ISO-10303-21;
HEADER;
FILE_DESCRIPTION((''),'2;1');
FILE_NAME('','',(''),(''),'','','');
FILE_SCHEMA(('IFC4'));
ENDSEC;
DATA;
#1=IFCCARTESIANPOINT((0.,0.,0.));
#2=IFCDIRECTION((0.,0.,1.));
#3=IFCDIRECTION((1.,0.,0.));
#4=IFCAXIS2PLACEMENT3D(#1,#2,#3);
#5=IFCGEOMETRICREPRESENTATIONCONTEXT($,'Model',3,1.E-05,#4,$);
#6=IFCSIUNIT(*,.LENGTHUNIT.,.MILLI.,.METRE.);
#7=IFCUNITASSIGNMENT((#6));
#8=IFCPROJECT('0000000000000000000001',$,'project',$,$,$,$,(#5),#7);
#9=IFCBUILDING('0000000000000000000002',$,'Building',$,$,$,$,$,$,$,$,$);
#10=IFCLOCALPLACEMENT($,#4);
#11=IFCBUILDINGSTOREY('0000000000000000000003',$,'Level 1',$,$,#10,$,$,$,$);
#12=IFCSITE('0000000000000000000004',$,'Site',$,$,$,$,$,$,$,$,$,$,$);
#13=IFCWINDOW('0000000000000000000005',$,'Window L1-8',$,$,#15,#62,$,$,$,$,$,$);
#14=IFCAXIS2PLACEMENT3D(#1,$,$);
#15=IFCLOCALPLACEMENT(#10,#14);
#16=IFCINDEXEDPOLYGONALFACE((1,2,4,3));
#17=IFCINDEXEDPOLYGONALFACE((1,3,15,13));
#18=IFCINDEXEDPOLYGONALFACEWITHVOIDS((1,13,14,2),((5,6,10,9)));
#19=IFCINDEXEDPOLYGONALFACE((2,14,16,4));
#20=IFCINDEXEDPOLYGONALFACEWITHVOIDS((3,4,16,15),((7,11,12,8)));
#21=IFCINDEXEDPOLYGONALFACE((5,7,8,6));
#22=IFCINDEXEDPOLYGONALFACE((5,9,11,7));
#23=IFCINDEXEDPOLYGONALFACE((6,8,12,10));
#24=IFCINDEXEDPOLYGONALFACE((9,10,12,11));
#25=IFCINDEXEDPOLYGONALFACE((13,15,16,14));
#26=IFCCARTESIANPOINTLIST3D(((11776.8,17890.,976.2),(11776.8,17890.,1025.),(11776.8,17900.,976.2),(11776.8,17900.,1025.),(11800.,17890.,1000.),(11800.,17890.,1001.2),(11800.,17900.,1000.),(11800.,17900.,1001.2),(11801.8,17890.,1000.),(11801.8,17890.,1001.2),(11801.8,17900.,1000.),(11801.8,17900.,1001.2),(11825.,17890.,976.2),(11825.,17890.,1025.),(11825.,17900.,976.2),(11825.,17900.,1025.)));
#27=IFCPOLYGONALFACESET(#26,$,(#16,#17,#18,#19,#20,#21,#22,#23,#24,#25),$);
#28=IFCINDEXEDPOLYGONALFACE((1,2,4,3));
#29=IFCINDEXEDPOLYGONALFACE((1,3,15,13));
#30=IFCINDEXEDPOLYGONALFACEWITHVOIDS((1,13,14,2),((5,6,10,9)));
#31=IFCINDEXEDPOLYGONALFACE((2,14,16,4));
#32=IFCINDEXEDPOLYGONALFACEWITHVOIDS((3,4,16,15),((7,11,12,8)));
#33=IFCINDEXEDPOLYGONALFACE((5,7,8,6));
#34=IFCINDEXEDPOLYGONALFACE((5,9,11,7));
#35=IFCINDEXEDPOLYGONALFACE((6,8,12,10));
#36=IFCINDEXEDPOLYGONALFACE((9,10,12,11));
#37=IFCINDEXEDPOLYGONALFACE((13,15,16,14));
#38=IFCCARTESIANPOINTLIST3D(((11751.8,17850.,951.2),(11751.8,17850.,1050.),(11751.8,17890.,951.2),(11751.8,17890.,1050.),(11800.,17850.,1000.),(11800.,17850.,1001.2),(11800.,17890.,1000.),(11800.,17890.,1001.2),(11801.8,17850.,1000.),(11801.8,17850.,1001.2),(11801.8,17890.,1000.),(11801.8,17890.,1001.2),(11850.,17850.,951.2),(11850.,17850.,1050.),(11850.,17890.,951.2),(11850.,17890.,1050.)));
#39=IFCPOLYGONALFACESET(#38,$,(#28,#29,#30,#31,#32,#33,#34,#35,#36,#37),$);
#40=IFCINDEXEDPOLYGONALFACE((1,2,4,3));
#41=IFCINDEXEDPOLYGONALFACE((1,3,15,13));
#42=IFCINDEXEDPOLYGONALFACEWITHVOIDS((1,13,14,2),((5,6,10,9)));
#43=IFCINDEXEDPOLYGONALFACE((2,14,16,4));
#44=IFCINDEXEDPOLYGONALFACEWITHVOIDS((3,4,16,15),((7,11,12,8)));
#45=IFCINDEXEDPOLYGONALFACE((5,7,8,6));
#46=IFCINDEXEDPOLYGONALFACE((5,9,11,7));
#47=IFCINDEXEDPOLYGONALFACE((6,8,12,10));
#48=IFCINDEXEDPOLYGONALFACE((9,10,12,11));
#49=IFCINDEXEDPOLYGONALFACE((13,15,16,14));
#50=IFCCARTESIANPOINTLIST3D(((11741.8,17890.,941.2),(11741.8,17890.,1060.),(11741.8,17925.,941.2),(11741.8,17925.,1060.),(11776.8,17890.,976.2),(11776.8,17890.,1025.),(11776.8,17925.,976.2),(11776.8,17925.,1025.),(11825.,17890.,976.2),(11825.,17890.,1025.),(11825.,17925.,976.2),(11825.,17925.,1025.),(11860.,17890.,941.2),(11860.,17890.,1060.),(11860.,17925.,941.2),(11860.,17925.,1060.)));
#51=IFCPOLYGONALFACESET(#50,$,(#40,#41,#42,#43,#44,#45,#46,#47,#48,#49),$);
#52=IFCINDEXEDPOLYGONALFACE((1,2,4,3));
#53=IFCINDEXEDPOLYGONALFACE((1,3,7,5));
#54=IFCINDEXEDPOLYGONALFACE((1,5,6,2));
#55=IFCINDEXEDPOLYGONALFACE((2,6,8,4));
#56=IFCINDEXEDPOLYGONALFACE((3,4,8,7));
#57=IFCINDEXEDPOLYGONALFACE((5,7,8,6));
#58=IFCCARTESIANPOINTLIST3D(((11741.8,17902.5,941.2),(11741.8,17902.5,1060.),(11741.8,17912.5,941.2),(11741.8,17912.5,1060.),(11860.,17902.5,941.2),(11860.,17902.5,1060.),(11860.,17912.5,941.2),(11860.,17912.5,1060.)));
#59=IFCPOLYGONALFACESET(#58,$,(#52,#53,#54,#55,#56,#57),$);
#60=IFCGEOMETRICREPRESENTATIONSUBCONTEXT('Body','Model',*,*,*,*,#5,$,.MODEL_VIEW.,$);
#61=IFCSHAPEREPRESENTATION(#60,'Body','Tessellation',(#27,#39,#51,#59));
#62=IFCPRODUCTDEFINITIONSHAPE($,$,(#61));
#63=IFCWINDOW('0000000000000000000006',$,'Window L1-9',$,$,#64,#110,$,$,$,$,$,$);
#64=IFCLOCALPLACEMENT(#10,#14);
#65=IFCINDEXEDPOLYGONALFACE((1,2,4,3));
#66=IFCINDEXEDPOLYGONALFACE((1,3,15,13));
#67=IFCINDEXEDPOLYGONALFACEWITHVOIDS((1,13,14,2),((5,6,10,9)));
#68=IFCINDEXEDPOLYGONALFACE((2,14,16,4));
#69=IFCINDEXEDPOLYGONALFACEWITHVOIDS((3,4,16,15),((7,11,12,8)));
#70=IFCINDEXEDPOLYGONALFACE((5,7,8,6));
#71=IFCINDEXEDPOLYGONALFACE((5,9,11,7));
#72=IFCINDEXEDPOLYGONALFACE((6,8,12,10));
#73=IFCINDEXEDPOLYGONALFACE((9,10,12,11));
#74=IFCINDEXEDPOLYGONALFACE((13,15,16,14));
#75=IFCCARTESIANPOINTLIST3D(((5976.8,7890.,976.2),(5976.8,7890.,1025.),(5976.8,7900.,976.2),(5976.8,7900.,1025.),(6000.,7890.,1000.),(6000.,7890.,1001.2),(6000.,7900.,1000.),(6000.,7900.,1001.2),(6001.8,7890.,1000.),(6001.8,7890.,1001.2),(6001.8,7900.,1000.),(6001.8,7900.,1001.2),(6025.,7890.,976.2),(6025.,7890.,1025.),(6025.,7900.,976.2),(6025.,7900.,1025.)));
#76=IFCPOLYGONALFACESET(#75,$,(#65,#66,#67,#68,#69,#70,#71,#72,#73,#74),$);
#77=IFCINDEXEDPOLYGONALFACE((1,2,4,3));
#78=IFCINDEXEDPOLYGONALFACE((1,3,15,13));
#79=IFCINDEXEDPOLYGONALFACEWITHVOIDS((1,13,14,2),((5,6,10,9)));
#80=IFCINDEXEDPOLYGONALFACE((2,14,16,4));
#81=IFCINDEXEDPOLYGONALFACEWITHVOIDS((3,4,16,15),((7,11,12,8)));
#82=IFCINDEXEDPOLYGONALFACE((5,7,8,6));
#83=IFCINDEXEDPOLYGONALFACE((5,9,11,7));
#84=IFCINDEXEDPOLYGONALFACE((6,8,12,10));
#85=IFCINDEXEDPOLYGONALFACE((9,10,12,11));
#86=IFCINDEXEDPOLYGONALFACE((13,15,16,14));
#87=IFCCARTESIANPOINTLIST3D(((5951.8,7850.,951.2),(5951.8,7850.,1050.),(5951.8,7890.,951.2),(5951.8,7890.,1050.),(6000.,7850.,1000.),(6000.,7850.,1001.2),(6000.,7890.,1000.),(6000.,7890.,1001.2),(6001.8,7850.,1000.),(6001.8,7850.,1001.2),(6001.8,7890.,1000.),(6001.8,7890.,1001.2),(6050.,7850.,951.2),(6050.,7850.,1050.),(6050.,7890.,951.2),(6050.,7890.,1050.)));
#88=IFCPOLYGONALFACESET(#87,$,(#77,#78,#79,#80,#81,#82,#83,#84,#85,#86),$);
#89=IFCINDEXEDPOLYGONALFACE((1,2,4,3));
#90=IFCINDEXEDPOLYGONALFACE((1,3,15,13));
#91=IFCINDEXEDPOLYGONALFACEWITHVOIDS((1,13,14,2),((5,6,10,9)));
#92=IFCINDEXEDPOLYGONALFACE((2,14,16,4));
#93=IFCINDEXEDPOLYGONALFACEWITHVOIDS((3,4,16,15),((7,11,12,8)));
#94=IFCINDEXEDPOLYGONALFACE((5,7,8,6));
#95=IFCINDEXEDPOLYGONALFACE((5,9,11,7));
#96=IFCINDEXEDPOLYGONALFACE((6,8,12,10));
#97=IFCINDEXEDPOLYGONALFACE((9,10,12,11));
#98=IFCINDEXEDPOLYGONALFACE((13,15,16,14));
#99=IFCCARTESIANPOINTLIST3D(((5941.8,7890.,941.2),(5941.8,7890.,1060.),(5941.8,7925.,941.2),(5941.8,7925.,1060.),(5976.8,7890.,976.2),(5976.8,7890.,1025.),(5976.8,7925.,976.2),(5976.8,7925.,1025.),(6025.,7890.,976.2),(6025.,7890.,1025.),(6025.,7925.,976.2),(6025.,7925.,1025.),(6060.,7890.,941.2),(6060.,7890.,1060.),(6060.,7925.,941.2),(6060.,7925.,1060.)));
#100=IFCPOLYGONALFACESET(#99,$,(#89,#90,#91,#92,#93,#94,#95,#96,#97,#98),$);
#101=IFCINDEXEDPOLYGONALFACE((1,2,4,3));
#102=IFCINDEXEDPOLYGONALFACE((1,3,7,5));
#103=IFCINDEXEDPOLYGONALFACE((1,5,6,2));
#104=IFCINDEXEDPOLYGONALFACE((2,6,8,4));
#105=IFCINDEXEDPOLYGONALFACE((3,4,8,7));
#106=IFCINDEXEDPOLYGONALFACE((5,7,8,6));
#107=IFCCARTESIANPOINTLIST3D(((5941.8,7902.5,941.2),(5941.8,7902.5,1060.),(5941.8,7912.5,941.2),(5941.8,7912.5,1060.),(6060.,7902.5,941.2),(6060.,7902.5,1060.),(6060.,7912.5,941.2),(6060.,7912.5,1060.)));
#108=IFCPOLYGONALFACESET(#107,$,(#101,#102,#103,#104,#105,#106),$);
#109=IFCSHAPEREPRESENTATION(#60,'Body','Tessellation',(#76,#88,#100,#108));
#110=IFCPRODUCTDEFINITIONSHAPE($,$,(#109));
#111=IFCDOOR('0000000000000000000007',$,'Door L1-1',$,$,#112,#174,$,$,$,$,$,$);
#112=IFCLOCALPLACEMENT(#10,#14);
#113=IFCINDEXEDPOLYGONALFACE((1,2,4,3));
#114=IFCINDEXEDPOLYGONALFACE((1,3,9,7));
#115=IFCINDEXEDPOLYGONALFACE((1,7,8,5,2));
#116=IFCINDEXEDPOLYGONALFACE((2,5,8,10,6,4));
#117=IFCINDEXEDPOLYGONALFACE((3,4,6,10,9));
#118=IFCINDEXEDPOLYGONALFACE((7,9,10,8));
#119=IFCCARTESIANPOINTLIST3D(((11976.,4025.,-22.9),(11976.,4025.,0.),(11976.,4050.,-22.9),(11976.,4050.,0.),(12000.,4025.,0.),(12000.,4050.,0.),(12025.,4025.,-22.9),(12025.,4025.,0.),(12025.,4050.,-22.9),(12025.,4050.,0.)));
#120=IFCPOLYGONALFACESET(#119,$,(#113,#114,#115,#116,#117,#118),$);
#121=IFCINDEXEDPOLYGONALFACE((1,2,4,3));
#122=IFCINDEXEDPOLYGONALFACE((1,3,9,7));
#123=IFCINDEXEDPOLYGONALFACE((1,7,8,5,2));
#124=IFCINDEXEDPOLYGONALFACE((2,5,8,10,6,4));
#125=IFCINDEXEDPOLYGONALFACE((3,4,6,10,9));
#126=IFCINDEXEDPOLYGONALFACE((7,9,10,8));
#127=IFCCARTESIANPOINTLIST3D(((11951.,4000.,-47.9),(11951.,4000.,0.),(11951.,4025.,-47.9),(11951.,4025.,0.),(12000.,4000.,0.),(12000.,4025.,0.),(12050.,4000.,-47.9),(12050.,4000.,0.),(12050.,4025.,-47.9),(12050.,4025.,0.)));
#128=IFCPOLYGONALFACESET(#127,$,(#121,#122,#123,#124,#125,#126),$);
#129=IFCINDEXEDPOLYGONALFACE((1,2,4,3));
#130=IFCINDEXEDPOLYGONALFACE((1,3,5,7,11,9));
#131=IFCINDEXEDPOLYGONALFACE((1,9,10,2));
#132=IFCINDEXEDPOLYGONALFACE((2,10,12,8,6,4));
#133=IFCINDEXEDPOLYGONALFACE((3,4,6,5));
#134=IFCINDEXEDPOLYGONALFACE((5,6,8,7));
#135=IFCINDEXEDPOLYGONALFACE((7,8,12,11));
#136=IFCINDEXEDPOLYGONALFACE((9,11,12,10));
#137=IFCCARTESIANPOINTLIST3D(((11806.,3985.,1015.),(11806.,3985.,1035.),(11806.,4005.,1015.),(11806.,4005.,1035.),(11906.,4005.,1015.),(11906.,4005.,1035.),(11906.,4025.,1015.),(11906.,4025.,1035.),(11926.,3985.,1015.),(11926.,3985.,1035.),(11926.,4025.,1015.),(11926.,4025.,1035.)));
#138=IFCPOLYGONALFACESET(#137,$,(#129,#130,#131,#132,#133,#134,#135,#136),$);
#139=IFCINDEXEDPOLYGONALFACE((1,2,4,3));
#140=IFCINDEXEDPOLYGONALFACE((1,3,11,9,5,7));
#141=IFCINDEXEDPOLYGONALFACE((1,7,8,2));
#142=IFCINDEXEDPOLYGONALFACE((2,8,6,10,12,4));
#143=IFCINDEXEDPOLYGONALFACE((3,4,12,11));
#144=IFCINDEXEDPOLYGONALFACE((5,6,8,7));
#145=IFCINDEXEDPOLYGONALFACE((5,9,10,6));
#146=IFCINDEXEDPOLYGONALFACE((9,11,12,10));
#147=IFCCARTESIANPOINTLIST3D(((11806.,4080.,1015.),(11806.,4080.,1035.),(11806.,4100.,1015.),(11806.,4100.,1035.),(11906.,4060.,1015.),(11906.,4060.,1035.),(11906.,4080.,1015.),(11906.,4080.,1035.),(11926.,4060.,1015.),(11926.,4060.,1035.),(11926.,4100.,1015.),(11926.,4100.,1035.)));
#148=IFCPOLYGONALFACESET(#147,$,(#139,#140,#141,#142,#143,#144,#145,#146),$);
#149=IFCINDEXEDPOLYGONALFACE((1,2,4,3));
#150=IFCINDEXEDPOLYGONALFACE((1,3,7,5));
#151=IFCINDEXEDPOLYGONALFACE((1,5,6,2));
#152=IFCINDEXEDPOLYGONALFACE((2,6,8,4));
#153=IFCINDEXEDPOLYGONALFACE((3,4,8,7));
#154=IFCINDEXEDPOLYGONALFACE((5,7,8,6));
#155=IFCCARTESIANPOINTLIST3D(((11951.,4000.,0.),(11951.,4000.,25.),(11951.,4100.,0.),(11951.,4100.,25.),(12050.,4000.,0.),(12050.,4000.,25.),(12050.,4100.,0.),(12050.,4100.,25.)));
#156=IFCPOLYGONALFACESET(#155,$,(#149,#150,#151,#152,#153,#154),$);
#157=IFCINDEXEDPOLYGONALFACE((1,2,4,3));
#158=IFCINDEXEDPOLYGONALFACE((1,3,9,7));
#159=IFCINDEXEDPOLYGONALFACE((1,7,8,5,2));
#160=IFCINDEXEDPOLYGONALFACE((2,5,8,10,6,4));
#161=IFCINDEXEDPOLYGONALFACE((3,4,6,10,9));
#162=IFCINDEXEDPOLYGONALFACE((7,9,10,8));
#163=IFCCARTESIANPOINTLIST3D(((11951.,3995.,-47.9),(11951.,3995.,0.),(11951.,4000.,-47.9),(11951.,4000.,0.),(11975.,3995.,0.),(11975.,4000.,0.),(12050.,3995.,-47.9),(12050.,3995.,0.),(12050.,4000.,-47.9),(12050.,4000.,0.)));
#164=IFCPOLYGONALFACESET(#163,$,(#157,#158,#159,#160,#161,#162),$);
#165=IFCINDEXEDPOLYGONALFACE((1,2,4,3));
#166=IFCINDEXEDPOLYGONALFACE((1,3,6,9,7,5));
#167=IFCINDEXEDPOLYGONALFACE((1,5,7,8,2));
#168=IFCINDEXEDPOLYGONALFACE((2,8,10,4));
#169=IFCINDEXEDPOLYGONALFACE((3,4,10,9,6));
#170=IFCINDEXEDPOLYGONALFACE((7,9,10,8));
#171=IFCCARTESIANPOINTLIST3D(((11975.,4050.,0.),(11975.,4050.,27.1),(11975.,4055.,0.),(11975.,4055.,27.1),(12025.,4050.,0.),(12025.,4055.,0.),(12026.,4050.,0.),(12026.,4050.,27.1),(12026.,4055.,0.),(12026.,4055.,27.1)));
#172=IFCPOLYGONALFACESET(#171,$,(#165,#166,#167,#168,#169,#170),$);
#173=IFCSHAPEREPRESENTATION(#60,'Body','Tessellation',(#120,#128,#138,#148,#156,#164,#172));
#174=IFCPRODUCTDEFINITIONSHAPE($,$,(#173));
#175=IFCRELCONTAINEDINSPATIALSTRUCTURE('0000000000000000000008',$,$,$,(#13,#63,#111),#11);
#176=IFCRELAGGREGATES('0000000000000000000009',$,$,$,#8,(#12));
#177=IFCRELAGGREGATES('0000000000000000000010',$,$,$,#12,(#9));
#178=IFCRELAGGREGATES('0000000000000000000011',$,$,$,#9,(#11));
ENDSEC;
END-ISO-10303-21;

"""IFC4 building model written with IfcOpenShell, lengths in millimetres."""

from ifc_helpers import new_model, si_unit, frame, origin_with_axes, place, context, subcontext, project, spatial, line, indexed_curve, outline, extrude, element, save


model = new_model("IFC4")

# Units and contexts
model_context = context("Model", 3, precision=1e-05, world=origin_with_axes())
body_context = subcontext(model_context, "Body", "Model", "MODEL_VIEW")
ifc_project = project(units=[si_unit("LENGTHUNIT", "METRE", prefix="MILLI")], contexts=[model_context])

# Site, building, storey
site = spatial("IfcSite", under=ifc_project, Name="Site")
building = spatial("IfcBuilding", under=site, Name="Building")
storey_placement = place(None, origin_with_axes())
storey = spatial("IfcBuildingStorey", under=building, at=storey_placement, Name="Level 1")

# Windows
for number, where, z_axis, x_axis, name in (
    (1, (11800.0, 17800.0, 1000.0), (0.0, 0.0, 1.0), (1.0, 0.0, 0.0), "Window L1-8"),
    (2, (6000.0, 7800.0, 1000.0), (0.0, 0.0, 1.0), (1.0, 0.0, 0.0), "Window L1-9"),
):
    element("IfcWindow", number, at=place(storey_placement, frame(where, z_axis=z_axis, x_axis=x_axis)), inside=storey, Name=name, context=body_context, shape_type="SweptSolid", body=[
        extrude(outline(indexed_curve([(0.0, 0.0), (1.8, 0.0), (1.8, 1.2), (0.0, 1.2)], segments=[line(1, 2, 3, 4, 1)]), holes=[indexed_curve([(25.0, 25.0), (-23.2, 25.0), (-23.2, -23.8), (25.0, -23.8)], segments=[line(1, 2, 3, 4, 1)])]), frame((0.0, 90.0, 0.0), z_axis=(0.0, -1.0, 0.0), x_axis=(1.0, 0.0, 0.0)), (0.0, 0.0, -1.0), 10.0),
        extrude(outline(indexed_curve([(0.0, 0.0), (1.8, 0.0), (1.8, 1.2), (0.0, 1.2)], segments=[line(1, 2, 3, 4, 1)]), holes=[indexed_curve([(50.0, 50.0), (-48.2, 50.0), (-48.2, -48.8), (50.0, -48.8)], segments=[line(1, 2, 3, 4, 1)])]), frame((0.0, 50.0, 0.0), z_axis=(0.0, -1.0, 0.0), x_axis=(1.0, 0.0, 0.0)), (0.0, 0.0, -1.0), 40.0),
        extrude(outline(indexed_curve([(0.0, 0.0), (-48.2, 0.0), (-48.2, -48.8), (0.0, -48.8)], segments=[line(1, 2, 3, 4, 1)]), holes=[indexed_curve([(35.0, 35.0), (-83.2, 35.0), (-83.2, -83.8), (35.0, -83.8)], segments=[line(1, 2, 3, 4, 1)])]), frame((25.0, 90.0, 25.0), z_axis=(0.0, -1.0, 0.0), x_axis=(1.0, 0.0, 0.0)), (0.0, 0.0, -1.0), 35.0),
        extrude(outline(indexed_curve([(35.0, 35.0), (-83.2, 35.0), (-83.2, -83.8), (35.0, -83.8)], segments=[line(1, 2, 3, 4, 1)])), frame((25.0, 102.5, 25.0), z_axis=(0.0, -1.0, 0.0), x_axis=(1.0, 0.0, 0.0)), (0.0, 0.0, -1.0), 10.0),
    ])

# Door
door_1_placement = place(storey_placement, frame((12000.0, 4000.0, 0.0), z_axis=(0.0, 0.0, 1.0), x_axis=(1.0, 0.0, 0.0)))
element("IfcDoor", 3, at=door_1_placement, inside=storey, Name="Door L1-1", context=body_context, shape_type="SweptSolid", body=[
    extrude(outline(indexed_curve([(0.0, 0.0), (0.0, 2.1), (1.0, 2.1), (1.0, 0.0), (-24.0, 0.0), (-24.0, -22.9), (25.0, -22.9), (25.0, 0.0)], segments=[line(1, 2, 3, 4, 5, 6, 7, 8, 1)])), frame((0.0, 25.0, 0.0), z_axis=(0.0, -1.0, 0.0), x_axis=(1.0, 0.0, 0.0)), (0.0, 0.0, -1.0), 25.0),
    extrude(outline(indexed_curve([(0.0, 0.0), (0.0, 2.1), (1.0, 2.1), (1.0, 0.0), (-49.0, 0.0), (-49.0, -47.9), (50.0, -47.9), (50.0, 0.0)], segments=[line(1, 2, 3, 4, 5, 6, 7, 8, 1)])), frame((0.0, 0.0, 0.0), z_axis=(0.0, -1.0, 0.0), x_axis=(1.0, 0.0, 0.0)), (0.0, 0.0, -1.0), 25.0),
    extrude(outline(indexed_curve([(0.0, 0.0), (-49.0, 0.0), (-49.0, 35.0), (0.0, 35.0)], segments=[line(1, 2, 3, 4, 1)])), frame((25.0, 25.0, 25.0), z_axis=(0.0, 0.0, 1.0), x_axis=(1.0, 0.0, 0.0)), (0.0, 0.0, 1.0), -47.9),
    extrude(outline(indexed_curve([(0.0, 0.0), (0.0, -40.0), (-120.0, -40.0), (-120.0, -20.0), (-20.0, -20.0), (-20.0, 0.0)], segments=[line(1, 2, 3, 4, 5, 6, 1)])), frame((-74.0, 25.0, 1015.0), z_axis=(0.0, 0.0, 1.0), x_axis=(1.0, 0.0, 0.0)), (0.0, 0.0, 1.0), 20.0),
    extrude(outline(indexed_curve([(0.0, 0.0), (0.0, 40.0), (-120.0, 40.0), (-120.0, 20.0), (-20.0, 20.0), (-20.0, 0.0)], segments=[line(1, 2, 3, 4, 5, 6, 1)])), frame((-74.0, 60.0, 1015.0), z_axis=(0.0, 0.0, 1.0), x_axis=(1.0, 0.0, 0.0)), (0.0, 0.0, 1.0), 20.0),
    extrude(outline(indexed_curve([(0.0, 0.0), (-99.0, 0.0), (-99.0, 100.0), (0.0, 100.0)], segments=[line(1, 2, 3, 4, 1)])), frame((50.0, 0.0, 0.0), z_axis=(0.0, 0.0, 1.0), x_axis=(1.0, 0.0, 0.0)), (0.0, 0.0, 1.0), 25.0),
    extrude(outline(indexed_curve([(0.0, 0.0), (0.0, 27.1), (51.0, 27.1), (51.0, 0.0), (-24.0, 0.0), (-24.0, -47.9), (75.0, -47.9), (75.0, 0.0)], segments=[line(1, 2, 3, 4, 5, 6, 7, 8, 1)])), frame((-25.0, -5.0, 0.0), z_axis=(0.0, -1.0, 0.0), x_axis=(1.0, 0.0, 0.0)), (0.0, 0.0, -1.0), 5.0),
    extrude(outline(indexed_curve([(0.0, 0.0), (0.0, 27.1), (51.0, 27.1), (51.0, 0.0), (1.0, 0.0), (1.0, -22.9), (50.0, -22.9), (50.0, 0.0)], segments=[line(1, 2, 3, 4, 5, 6, 7, 8, 1)])), frame((-25.0, 50.0, 0.0), z_axis=(0.0, -1.0, 0.0), x_axis=(1.0, 0.0, 0.0)), (0.0, 0.0, -1.0), 5.0),
])

save(model, "model.ifc")
